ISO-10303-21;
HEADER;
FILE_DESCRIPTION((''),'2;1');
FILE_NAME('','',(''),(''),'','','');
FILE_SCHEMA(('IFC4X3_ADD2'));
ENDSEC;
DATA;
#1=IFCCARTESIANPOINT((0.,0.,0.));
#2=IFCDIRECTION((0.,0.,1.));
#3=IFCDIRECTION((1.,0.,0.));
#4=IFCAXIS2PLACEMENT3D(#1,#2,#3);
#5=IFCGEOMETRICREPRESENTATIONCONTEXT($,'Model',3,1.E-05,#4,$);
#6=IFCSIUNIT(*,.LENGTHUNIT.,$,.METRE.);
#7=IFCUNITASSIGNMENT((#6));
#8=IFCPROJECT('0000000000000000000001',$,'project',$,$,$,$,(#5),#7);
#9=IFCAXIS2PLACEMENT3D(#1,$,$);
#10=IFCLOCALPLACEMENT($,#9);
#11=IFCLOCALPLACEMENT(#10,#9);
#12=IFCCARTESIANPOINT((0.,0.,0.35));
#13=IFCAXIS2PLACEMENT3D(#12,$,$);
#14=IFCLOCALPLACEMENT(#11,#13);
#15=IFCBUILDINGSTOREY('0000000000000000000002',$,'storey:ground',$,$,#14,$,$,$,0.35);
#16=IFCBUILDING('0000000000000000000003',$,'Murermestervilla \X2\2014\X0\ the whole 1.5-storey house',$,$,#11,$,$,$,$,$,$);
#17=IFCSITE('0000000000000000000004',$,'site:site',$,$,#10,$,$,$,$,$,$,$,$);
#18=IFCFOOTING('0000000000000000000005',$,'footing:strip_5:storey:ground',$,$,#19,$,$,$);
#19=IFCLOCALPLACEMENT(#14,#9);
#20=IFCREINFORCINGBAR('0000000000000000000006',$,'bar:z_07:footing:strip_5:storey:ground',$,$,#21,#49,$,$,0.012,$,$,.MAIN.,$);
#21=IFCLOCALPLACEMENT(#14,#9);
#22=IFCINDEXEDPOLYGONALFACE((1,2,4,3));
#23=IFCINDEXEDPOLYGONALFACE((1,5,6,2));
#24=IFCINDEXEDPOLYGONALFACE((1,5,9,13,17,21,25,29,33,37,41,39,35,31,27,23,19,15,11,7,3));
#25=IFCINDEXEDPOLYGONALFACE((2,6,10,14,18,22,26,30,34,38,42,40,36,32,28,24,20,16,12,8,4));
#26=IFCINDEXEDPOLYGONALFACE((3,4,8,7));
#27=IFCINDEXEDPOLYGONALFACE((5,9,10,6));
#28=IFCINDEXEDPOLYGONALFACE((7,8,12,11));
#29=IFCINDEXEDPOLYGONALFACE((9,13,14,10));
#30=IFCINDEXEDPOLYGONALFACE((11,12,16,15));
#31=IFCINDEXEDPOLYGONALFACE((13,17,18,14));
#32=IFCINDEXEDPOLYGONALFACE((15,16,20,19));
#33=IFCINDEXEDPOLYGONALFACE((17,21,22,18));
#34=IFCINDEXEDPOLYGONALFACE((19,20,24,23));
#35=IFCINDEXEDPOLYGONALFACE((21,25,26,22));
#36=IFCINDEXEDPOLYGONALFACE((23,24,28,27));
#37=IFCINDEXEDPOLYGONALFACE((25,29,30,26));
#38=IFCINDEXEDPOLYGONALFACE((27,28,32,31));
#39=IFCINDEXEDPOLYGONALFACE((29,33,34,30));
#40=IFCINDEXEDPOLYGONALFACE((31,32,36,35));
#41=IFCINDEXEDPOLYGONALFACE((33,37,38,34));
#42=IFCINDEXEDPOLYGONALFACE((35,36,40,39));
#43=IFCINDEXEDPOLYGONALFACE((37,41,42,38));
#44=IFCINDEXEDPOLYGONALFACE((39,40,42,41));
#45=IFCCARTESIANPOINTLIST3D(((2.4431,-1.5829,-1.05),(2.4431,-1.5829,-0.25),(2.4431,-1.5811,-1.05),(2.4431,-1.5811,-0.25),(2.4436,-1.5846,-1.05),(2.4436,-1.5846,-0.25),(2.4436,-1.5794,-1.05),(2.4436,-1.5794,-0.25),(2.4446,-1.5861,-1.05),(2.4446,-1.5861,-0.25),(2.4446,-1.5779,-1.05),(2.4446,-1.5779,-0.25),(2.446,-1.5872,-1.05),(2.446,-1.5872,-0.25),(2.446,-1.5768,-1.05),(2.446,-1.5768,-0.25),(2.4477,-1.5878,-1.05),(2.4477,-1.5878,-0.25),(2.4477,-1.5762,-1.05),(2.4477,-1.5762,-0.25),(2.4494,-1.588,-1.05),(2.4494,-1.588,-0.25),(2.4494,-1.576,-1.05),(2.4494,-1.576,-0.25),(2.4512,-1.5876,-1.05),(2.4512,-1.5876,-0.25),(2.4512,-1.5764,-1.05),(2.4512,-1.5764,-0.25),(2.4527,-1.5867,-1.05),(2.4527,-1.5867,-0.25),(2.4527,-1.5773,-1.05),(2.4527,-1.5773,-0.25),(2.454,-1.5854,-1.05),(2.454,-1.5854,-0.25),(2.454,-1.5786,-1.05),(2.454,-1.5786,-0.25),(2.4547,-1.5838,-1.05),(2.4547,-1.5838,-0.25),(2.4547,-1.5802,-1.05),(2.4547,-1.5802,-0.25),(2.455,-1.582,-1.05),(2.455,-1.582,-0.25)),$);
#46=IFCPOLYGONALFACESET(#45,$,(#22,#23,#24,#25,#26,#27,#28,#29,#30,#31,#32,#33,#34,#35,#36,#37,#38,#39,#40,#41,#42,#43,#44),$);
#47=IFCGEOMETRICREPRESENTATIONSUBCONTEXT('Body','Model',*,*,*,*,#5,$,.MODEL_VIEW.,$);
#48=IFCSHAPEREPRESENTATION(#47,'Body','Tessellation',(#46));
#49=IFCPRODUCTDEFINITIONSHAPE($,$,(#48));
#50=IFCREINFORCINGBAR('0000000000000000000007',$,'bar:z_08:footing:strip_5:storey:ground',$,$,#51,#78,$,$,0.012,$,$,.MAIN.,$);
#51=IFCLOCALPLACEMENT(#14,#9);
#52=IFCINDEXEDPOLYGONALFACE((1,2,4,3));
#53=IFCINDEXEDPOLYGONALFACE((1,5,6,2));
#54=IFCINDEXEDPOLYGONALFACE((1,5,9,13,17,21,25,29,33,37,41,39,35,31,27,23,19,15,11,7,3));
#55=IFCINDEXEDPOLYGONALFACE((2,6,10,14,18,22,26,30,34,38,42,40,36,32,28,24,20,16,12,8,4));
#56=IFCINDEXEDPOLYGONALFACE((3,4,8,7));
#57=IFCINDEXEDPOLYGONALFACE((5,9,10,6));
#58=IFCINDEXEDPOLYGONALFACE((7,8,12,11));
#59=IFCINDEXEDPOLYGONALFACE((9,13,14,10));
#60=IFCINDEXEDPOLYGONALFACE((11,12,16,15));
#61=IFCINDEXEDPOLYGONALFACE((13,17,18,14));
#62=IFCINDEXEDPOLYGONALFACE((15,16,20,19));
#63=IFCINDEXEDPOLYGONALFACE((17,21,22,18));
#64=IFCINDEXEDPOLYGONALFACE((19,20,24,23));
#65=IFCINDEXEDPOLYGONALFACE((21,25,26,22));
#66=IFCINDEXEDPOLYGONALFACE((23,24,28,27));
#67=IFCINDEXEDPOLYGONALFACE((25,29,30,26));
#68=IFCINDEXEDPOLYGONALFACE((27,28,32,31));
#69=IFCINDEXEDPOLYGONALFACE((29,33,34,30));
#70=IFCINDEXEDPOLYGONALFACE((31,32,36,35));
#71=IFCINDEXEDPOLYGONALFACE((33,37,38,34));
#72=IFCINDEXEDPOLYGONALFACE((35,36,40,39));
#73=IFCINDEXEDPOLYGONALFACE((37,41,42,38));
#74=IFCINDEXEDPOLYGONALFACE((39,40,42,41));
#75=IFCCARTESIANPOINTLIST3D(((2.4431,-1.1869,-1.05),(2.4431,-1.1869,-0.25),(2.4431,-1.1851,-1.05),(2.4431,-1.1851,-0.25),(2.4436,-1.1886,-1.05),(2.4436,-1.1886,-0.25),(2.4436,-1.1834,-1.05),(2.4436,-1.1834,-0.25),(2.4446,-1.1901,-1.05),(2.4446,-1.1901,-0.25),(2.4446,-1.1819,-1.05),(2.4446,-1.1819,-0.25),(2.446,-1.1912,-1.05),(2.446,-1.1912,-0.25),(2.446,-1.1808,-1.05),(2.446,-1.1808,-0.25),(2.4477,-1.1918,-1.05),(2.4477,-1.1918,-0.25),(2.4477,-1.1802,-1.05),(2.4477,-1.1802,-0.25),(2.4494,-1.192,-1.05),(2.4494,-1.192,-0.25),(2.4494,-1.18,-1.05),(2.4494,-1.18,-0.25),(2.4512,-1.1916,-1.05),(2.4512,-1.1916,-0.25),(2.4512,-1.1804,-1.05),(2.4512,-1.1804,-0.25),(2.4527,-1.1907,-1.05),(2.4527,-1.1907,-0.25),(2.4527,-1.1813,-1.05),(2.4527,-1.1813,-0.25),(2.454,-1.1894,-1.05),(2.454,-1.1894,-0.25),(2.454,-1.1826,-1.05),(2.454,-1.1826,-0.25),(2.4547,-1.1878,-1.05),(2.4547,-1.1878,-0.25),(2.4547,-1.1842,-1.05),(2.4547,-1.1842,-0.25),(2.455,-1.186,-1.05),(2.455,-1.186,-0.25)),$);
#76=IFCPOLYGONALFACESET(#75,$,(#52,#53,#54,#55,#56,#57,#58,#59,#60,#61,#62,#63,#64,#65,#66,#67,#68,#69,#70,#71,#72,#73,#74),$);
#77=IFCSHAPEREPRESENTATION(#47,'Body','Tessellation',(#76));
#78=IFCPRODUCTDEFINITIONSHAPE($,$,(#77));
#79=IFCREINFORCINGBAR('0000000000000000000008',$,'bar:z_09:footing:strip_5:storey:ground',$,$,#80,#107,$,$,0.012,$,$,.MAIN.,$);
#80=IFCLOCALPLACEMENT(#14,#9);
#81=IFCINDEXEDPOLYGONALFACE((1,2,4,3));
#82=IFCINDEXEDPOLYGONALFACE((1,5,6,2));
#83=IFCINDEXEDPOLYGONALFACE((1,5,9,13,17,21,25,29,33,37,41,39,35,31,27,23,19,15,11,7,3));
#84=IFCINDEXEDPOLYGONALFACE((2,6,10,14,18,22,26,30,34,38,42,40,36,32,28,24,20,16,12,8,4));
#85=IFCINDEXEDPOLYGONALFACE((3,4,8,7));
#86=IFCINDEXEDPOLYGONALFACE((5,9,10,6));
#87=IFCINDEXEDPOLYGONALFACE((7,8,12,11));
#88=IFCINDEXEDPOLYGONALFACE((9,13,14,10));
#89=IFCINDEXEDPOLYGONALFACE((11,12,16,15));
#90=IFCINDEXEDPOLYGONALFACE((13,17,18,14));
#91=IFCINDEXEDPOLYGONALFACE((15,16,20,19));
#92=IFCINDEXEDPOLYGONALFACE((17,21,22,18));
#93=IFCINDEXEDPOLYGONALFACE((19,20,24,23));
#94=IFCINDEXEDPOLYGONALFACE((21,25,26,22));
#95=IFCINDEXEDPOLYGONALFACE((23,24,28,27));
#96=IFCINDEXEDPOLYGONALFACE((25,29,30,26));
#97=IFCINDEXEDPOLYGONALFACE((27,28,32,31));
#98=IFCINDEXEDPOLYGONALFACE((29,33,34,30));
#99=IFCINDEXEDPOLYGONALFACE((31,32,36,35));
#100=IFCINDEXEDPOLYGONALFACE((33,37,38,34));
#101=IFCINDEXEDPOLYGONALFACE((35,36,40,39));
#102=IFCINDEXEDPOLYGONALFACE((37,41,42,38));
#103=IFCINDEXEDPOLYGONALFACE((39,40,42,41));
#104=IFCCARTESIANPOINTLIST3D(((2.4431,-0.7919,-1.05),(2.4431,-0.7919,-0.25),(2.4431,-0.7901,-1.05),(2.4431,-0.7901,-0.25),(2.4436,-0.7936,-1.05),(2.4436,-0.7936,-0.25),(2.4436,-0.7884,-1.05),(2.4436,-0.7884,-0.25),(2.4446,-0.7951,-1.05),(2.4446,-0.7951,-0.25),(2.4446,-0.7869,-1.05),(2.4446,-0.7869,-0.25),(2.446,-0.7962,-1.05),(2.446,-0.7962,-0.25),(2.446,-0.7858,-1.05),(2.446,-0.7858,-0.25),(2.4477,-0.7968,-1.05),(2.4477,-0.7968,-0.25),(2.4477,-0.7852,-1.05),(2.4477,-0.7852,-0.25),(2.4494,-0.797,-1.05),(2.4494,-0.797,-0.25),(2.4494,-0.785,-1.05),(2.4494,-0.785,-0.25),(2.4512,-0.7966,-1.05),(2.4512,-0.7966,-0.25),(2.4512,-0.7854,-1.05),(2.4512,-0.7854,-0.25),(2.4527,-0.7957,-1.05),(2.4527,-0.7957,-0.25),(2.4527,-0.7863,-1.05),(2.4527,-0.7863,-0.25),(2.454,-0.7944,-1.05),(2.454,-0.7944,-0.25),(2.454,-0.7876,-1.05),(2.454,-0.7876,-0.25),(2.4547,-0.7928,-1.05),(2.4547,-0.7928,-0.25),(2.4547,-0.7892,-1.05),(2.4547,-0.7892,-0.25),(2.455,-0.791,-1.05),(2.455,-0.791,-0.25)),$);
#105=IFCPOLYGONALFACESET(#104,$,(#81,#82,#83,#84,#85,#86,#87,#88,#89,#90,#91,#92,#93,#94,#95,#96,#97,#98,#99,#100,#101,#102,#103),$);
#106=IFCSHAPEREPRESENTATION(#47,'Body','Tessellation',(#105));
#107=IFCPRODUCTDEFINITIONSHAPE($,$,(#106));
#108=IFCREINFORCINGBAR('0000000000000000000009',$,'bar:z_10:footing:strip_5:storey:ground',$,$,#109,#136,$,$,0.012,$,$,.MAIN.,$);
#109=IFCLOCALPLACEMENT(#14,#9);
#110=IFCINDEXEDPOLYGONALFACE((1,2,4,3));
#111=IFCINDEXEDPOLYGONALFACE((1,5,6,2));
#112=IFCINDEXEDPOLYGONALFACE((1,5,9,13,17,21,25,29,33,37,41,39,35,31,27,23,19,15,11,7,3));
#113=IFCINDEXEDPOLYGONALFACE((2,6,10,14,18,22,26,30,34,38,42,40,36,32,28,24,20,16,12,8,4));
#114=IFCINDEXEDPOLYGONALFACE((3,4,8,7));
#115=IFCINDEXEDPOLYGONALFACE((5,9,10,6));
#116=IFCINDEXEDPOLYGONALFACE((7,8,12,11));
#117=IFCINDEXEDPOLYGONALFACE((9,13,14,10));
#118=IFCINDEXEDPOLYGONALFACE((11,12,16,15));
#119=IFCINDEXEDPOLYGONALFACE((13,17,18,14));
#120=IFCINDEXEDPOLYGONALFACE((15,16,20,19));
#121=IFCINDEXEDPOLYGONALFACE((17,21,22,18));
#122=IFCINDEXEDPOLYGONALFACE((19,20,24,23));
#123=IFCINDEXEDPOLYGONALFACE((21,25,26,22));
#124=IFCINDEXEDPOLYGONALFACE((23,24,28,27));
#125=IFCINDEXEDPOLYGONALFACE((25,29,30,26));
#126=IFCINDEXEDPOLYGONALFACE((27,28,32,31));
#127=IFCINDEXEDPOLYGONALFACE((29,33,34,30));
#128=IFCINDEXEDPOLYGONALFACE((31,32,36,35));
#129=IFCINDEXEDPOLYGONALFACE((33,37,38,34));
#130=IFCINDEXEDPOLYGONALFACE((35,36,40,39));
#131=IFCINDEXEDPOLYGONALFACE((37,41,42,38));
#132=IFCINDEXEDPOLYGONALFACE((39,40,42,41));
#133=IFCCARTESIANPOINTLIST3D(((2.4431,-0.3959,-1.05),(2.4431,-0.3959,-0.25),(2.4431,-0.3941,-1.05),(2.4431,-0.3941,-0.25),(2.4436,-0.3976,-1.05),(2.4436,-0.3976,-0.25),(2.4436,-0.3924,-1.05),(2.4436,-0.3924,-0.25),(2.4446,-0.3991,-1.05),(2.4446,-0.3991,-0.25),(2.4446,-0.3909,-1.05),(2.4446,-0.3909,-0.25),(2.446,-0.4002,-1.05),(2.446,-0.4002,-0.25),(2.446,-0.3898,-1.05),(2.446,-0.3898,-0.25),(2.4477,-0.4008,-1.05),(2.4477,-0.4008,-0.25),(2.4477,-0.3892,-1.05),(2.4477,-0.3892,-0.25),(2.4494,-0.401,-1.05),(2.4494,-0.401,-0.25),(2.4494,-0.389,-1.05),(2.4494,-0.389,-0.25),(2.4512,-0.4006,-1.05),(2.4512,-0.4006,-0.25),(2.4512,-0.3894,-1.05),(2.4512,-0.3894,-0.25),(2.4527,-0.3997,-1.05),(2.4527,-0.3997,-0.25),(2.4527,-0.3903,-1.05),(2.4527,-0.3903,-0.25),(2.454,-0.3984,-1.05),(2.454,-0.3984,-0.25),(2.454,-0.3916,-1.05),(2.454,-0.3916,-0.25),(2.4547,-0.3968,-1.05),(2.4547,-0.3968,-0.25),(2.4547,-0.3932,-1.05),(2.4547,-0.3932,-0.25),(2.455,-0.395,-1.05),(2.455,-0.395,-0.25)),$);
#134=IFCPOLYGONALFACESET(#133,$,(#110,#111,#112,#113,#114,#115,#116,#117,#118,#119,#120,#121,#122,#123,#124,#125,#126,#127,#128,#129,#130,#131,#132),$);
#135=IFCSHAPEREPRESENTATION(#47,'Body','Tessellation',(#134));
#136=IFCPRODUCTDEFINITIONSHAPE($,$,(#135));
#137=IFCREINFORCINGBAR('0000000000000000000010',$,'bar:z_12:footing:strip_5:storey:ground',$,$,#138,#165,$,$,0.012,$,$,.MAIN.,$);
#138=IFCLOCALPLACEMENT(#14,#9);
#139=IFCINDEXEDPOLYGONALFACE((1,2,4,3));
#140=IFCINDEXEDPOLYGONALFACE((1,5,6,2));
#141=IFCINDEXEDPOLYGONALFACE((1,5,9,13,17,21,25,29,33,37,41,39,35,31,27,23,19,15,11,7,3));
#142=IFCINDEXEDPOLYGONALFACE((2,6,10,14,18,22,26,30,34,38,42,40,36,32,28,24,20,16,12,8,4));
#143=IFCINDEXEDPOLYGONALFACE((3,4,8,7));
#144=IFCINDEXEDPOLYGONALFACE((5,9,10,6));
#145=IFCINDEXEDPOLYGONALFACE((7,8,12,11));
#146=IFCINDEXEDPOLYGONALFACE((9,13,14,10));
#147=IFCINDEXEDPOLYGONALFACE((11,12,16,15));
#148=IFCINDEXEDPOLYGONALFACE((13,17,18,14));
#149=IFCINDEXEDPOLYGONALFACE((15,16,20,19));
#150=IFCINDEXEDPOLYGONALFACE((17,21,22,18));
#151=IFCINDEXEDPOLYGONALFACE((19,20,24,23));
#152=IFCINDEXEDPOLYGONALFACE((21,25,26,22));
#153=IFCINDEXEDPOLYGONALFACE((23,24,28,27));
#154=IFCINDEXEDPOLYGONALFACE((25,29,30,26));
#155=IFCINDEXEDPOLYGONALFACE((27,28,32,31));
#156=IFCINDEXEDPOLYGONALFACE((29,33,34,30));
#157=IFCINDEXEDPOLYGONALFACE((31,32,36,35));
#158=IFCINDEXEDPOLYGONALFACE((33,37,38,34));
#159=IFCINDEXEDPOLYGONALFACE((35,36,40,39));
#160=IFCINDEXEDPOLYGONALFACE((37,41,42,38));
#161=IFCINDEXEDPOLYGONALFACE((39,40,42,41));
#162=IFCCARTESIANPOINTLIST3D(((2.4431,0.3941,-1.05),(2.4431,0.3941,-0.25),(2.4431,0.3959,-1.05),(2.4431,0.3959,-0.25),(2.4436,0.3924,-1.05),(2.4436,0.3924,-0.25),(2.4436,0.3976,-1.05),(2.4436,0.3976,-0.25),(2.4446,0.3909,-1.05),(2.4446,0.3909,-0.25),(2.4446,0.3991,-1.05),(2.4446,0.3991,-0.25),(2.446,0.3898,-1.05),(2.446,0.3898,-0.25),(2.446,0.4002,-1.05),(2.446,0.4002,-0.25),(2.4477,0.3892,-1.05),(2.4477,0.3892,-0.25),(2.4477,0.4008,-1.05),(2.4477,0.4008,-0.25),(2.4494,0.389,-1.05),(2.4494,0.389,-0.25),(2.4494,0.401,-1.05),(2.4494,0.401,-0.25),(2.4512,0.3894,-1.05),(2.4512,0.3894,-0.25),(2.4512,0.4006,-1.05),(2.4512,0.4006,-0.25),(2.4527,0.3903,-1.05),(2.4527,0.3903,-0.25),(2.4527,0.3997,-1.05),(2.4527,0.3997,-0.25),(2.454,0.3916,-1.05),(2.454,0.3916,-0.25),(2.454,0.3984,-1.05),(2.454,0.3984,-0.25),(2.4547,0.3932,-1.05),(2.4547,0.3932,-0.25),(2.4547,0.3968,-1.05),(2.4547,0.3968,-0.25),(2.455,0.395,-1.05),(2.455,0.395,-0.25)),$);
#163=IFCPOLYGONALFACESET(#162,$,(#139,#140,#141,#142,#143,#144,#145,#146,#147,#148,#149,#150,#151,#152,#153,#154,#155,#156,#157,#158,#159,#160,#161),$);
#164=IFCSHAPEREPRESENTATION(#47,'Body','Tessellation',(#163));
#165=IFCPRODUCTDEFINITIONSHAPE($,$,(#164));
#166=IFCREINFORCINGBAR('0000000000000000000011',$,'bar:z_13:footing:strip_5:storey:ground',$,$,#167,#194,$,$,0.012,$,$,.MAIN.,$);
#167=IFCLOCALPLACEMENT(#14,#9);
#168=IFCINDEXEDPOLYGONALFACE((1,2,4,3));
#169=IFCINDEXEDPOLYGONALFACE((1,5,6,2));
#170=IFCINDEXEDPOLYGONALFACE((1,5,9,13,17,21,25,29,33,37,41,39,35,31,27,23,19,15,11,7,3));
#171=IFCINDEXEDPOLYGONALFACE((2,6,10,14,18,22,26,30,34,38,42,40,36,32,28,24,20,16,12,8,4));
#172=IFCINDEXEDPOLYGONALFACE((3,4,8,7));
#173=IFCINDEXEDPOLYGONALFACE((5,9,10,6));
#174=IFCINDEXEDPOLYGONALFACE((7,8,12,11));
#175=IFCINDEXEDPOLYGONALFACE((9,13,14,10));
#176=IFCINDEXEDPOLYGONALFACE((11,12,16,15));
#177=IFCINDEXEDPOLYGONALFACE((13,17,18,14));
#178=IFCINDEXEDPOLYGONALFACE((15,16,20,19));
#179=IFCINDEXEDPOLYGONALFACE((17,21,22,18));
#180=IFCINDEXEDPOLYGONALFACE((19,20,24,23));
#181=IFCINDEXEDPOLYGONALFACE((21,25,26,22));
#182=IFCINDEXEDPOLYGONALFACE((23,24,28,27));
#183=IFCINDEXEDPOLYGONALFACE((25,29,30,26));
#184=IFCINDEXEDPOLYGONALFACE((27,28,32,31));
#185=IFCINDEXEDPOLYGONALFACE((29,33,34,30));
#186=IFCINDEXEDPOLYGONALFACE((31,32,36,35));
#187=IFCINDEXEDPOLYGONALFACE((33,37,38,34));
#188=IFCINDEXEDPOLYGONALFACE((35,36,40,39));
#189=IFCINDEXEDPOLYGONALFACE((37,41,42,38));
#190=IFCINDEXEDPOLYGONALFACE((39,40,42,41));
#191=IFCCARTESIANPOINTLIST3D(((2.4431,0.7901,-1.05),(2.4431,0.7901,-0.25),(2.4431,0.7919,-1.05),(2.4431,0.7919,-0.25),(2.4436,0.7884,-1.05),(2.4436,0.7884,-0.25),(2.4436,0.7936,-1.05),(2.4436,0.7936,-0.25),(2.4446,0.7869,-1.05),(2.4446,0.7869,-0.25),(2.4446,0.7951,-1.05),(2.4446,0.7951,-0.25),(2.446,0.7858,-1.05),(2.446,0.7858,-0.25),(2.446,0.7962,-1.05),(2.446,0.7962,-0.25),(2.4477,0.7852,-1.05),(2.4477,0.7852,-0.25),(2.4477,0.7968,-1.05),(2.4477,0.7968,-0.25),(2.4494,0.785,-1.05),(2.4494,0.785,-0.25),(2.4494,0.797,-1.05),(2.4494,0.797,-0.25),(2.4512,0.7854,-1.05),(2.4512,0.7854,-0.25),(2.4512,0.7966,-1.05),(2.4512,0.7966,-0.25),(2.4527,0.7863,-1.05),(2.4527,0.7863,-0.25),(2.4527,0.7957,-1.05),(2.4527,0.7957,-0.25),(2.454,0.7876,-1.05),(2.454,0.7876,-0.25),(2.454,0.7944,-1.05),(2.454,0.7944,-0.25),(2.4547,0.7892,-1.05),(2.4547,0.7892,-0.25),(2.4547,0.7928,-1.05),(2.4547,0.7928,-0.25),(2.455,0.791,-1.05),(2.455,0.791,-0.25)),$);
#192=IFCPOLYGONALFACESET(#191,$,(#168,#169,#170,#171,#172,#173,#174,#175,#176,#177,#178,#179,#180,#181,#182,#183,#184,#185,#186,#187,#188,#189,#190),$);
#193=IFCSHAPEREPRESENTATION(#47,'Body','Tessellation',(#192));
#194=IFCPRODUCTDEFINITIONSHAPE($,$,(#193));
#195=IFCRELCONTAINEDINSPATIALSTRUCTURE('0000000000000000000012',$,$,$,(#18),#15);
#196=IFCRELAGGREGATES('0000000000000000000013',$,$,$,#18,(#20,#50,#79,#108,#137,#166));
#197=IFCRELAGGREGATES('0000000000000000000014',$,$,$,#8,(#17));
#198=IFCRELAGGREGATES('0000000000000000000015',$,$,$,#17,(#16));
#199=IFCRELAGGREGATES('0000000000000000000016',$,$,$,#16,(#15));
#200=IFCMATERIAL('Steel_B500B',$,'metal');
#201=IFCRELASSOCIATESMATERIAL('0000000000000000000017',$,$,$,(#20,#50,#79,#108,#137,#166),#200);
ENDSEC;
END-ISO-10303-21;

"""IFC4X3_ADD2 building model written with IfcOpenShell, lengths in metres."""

from ifc_helpers import new_model, entity, si_unit, frame, origin, origin_with_axes, place, context, subcontext, project, spatial, material, element, aggregate, save


model = new_model("IFC4X3_ADD2")

# Units and contexts
model_context = context("Model", 3, precision=1e-05, world=origin_with_axes())
body_context = subcontext(model_context, "Body", "Model", "MODEL_VIEW")
ifc_project = project(units=[si_unit("LENGTHUNIT", "METRE")], contexts=[model_context])

# Site, building, storey
placement_1 = place(None, origin())
site = spatial("IfcSite", under=ifc_project, at=placement_1, Name="site:site")
building_placement = place(placement_1, origin())
building = spatial("IfcBuilding", under=site, at=building_placement, Name="Murermestervilla — the whole 1.5-storey house")
storey_placement = place(building_placement, frame((0.0, 0.0, 0.35)))
storey = spatial("IfcBuildingStorey", under=building, at=storey_placement, Name="storey:ground", Elevation=0.35)

# Footing, reinforcing bars
placement_2 = place(storey_placement, frame((0.0, 0.0, -0.35)))
ifc_material = material(Name="Steel_B500B", Category="metal")
footing_1 = element("IfcFooting", 1, at=placement_2, inside=storey, Name="footing:strip_5:storey:ground")
reinforcing_bar_1 = element("IfcReinforcingBar", 2, at=placement_1, material=ifc_material, Name="bar:z_07:footing:strip_5:storey:ground", NominalDiameter=0.012, PredefinedType="MAIN", context=body_context, shape_type="AdvancedSweptSolid", body=[
    entity("IfcSweptDiskSolid", entity("IfcPolyline", [entity("IfcCartesianPoint", [2.449, -1.582, -0.7]), entity("IfcCartesianPoint", [2.449, -1.582, 0.1])]), 0.006),
])
reinforcing_bar_2 = element("IfcReinforcingBar", 3, at=placement_1, material=ifc_material, Name="bar:z_08:footing:strip_5:storey:ground", NominalDiameter=0.012, PredefinedType="MAIN", context=body_context, shape_type="AdvancedSweptSolid", body=[
    entity("IfcSweptDiskSolid", entity("IfcPolyline", [entity("IfcCartesianPoint", [2.449, -1.186, -0.7]), entity("IfcCartesianPoint", [2.449, -1.186, 0.1])]), 0.006),
])
reinforcing_bar_3 = element("IfcReinforcingBar", 4, at=placement_1, material=ifc_material, Name="bar:z_09:footing:strip_5:storey:ground", NominalDiameter=0.012, PredefinedType="MAIN", context=body_context, shape_type="AdvancedSweptSolid", body=[
    entity("IfcSweptDiskSolid", entity("IfcPolyline", [entity("IfcCartesianPoint", [2.449, -0.791, -0.7]), entity("IfcCartesianPoint", [2.449, -0.791, 0.1])]), 0.006),
])
reinforcing_bar_4 = element("IfcReinforcingBar", 5, at=placement_1, material=ifc_material, Name="bar:z_10:footing:strip_5:storey:ground", NominalDiameter=0.012, PredefinedType="MAIN", context=body_context, shape_type="AdvancedSweptSolid", body=[
    entity("IfcSweptDiskSolid", entity("IfcPolyline", [entity("IfcCartesianPoint", [2.449, -0.395, -0.7]), entity("IfcCartesianPoint", [2.449, -0.395, 0.1])]), 0.006),
])
reinforcing_bar_5 = element("IfcReinforcingBar", 6, at=placement_1, material=ifc_material, Name="bar:z_12:footing:strip_5:storey:ground", NominalDiameter=0.012, PredefinedType="MAIN", context=body_context, shape_type="AdvancedSweptSolid", body=[
    entity("IfcSweptDiskSolid", entity("IfcPolyline", [entity("IfcCartesianPoint", [2.449, 0.395, -0.7]), entity("IfcCartesianPoint", [2.449, 0.395, 0.1])]), 0.006),
])
reinforcing_bar_6 = element("IfcReinforcingBar", 7, at=placement_1, material=ifc_material, Name="bar:z_13:footing:strip_5:storey:ground", NominalDiameter=0.012, PredefinedType="MAIN", context=body_context, shape_type="AdvancedSweptSolid", body=[
    entity("IfcSweptDiskSolid", entity("IfcPolyline", [entity("IfcCartesianPoint", [2.449, 0.791, -0.7]), entity("IfcCartesianPoint", [2.449, 0.791, 0.1])]), 0.006),
])
aggregate(footing_1, [reinforcing_bar_1, reinforcing_bar_2, reinforcing_bar_3, reinforcing_bar_4, reinforcing_bar_5, reinforcing_bar_6])

save(model, "model.ifc")
